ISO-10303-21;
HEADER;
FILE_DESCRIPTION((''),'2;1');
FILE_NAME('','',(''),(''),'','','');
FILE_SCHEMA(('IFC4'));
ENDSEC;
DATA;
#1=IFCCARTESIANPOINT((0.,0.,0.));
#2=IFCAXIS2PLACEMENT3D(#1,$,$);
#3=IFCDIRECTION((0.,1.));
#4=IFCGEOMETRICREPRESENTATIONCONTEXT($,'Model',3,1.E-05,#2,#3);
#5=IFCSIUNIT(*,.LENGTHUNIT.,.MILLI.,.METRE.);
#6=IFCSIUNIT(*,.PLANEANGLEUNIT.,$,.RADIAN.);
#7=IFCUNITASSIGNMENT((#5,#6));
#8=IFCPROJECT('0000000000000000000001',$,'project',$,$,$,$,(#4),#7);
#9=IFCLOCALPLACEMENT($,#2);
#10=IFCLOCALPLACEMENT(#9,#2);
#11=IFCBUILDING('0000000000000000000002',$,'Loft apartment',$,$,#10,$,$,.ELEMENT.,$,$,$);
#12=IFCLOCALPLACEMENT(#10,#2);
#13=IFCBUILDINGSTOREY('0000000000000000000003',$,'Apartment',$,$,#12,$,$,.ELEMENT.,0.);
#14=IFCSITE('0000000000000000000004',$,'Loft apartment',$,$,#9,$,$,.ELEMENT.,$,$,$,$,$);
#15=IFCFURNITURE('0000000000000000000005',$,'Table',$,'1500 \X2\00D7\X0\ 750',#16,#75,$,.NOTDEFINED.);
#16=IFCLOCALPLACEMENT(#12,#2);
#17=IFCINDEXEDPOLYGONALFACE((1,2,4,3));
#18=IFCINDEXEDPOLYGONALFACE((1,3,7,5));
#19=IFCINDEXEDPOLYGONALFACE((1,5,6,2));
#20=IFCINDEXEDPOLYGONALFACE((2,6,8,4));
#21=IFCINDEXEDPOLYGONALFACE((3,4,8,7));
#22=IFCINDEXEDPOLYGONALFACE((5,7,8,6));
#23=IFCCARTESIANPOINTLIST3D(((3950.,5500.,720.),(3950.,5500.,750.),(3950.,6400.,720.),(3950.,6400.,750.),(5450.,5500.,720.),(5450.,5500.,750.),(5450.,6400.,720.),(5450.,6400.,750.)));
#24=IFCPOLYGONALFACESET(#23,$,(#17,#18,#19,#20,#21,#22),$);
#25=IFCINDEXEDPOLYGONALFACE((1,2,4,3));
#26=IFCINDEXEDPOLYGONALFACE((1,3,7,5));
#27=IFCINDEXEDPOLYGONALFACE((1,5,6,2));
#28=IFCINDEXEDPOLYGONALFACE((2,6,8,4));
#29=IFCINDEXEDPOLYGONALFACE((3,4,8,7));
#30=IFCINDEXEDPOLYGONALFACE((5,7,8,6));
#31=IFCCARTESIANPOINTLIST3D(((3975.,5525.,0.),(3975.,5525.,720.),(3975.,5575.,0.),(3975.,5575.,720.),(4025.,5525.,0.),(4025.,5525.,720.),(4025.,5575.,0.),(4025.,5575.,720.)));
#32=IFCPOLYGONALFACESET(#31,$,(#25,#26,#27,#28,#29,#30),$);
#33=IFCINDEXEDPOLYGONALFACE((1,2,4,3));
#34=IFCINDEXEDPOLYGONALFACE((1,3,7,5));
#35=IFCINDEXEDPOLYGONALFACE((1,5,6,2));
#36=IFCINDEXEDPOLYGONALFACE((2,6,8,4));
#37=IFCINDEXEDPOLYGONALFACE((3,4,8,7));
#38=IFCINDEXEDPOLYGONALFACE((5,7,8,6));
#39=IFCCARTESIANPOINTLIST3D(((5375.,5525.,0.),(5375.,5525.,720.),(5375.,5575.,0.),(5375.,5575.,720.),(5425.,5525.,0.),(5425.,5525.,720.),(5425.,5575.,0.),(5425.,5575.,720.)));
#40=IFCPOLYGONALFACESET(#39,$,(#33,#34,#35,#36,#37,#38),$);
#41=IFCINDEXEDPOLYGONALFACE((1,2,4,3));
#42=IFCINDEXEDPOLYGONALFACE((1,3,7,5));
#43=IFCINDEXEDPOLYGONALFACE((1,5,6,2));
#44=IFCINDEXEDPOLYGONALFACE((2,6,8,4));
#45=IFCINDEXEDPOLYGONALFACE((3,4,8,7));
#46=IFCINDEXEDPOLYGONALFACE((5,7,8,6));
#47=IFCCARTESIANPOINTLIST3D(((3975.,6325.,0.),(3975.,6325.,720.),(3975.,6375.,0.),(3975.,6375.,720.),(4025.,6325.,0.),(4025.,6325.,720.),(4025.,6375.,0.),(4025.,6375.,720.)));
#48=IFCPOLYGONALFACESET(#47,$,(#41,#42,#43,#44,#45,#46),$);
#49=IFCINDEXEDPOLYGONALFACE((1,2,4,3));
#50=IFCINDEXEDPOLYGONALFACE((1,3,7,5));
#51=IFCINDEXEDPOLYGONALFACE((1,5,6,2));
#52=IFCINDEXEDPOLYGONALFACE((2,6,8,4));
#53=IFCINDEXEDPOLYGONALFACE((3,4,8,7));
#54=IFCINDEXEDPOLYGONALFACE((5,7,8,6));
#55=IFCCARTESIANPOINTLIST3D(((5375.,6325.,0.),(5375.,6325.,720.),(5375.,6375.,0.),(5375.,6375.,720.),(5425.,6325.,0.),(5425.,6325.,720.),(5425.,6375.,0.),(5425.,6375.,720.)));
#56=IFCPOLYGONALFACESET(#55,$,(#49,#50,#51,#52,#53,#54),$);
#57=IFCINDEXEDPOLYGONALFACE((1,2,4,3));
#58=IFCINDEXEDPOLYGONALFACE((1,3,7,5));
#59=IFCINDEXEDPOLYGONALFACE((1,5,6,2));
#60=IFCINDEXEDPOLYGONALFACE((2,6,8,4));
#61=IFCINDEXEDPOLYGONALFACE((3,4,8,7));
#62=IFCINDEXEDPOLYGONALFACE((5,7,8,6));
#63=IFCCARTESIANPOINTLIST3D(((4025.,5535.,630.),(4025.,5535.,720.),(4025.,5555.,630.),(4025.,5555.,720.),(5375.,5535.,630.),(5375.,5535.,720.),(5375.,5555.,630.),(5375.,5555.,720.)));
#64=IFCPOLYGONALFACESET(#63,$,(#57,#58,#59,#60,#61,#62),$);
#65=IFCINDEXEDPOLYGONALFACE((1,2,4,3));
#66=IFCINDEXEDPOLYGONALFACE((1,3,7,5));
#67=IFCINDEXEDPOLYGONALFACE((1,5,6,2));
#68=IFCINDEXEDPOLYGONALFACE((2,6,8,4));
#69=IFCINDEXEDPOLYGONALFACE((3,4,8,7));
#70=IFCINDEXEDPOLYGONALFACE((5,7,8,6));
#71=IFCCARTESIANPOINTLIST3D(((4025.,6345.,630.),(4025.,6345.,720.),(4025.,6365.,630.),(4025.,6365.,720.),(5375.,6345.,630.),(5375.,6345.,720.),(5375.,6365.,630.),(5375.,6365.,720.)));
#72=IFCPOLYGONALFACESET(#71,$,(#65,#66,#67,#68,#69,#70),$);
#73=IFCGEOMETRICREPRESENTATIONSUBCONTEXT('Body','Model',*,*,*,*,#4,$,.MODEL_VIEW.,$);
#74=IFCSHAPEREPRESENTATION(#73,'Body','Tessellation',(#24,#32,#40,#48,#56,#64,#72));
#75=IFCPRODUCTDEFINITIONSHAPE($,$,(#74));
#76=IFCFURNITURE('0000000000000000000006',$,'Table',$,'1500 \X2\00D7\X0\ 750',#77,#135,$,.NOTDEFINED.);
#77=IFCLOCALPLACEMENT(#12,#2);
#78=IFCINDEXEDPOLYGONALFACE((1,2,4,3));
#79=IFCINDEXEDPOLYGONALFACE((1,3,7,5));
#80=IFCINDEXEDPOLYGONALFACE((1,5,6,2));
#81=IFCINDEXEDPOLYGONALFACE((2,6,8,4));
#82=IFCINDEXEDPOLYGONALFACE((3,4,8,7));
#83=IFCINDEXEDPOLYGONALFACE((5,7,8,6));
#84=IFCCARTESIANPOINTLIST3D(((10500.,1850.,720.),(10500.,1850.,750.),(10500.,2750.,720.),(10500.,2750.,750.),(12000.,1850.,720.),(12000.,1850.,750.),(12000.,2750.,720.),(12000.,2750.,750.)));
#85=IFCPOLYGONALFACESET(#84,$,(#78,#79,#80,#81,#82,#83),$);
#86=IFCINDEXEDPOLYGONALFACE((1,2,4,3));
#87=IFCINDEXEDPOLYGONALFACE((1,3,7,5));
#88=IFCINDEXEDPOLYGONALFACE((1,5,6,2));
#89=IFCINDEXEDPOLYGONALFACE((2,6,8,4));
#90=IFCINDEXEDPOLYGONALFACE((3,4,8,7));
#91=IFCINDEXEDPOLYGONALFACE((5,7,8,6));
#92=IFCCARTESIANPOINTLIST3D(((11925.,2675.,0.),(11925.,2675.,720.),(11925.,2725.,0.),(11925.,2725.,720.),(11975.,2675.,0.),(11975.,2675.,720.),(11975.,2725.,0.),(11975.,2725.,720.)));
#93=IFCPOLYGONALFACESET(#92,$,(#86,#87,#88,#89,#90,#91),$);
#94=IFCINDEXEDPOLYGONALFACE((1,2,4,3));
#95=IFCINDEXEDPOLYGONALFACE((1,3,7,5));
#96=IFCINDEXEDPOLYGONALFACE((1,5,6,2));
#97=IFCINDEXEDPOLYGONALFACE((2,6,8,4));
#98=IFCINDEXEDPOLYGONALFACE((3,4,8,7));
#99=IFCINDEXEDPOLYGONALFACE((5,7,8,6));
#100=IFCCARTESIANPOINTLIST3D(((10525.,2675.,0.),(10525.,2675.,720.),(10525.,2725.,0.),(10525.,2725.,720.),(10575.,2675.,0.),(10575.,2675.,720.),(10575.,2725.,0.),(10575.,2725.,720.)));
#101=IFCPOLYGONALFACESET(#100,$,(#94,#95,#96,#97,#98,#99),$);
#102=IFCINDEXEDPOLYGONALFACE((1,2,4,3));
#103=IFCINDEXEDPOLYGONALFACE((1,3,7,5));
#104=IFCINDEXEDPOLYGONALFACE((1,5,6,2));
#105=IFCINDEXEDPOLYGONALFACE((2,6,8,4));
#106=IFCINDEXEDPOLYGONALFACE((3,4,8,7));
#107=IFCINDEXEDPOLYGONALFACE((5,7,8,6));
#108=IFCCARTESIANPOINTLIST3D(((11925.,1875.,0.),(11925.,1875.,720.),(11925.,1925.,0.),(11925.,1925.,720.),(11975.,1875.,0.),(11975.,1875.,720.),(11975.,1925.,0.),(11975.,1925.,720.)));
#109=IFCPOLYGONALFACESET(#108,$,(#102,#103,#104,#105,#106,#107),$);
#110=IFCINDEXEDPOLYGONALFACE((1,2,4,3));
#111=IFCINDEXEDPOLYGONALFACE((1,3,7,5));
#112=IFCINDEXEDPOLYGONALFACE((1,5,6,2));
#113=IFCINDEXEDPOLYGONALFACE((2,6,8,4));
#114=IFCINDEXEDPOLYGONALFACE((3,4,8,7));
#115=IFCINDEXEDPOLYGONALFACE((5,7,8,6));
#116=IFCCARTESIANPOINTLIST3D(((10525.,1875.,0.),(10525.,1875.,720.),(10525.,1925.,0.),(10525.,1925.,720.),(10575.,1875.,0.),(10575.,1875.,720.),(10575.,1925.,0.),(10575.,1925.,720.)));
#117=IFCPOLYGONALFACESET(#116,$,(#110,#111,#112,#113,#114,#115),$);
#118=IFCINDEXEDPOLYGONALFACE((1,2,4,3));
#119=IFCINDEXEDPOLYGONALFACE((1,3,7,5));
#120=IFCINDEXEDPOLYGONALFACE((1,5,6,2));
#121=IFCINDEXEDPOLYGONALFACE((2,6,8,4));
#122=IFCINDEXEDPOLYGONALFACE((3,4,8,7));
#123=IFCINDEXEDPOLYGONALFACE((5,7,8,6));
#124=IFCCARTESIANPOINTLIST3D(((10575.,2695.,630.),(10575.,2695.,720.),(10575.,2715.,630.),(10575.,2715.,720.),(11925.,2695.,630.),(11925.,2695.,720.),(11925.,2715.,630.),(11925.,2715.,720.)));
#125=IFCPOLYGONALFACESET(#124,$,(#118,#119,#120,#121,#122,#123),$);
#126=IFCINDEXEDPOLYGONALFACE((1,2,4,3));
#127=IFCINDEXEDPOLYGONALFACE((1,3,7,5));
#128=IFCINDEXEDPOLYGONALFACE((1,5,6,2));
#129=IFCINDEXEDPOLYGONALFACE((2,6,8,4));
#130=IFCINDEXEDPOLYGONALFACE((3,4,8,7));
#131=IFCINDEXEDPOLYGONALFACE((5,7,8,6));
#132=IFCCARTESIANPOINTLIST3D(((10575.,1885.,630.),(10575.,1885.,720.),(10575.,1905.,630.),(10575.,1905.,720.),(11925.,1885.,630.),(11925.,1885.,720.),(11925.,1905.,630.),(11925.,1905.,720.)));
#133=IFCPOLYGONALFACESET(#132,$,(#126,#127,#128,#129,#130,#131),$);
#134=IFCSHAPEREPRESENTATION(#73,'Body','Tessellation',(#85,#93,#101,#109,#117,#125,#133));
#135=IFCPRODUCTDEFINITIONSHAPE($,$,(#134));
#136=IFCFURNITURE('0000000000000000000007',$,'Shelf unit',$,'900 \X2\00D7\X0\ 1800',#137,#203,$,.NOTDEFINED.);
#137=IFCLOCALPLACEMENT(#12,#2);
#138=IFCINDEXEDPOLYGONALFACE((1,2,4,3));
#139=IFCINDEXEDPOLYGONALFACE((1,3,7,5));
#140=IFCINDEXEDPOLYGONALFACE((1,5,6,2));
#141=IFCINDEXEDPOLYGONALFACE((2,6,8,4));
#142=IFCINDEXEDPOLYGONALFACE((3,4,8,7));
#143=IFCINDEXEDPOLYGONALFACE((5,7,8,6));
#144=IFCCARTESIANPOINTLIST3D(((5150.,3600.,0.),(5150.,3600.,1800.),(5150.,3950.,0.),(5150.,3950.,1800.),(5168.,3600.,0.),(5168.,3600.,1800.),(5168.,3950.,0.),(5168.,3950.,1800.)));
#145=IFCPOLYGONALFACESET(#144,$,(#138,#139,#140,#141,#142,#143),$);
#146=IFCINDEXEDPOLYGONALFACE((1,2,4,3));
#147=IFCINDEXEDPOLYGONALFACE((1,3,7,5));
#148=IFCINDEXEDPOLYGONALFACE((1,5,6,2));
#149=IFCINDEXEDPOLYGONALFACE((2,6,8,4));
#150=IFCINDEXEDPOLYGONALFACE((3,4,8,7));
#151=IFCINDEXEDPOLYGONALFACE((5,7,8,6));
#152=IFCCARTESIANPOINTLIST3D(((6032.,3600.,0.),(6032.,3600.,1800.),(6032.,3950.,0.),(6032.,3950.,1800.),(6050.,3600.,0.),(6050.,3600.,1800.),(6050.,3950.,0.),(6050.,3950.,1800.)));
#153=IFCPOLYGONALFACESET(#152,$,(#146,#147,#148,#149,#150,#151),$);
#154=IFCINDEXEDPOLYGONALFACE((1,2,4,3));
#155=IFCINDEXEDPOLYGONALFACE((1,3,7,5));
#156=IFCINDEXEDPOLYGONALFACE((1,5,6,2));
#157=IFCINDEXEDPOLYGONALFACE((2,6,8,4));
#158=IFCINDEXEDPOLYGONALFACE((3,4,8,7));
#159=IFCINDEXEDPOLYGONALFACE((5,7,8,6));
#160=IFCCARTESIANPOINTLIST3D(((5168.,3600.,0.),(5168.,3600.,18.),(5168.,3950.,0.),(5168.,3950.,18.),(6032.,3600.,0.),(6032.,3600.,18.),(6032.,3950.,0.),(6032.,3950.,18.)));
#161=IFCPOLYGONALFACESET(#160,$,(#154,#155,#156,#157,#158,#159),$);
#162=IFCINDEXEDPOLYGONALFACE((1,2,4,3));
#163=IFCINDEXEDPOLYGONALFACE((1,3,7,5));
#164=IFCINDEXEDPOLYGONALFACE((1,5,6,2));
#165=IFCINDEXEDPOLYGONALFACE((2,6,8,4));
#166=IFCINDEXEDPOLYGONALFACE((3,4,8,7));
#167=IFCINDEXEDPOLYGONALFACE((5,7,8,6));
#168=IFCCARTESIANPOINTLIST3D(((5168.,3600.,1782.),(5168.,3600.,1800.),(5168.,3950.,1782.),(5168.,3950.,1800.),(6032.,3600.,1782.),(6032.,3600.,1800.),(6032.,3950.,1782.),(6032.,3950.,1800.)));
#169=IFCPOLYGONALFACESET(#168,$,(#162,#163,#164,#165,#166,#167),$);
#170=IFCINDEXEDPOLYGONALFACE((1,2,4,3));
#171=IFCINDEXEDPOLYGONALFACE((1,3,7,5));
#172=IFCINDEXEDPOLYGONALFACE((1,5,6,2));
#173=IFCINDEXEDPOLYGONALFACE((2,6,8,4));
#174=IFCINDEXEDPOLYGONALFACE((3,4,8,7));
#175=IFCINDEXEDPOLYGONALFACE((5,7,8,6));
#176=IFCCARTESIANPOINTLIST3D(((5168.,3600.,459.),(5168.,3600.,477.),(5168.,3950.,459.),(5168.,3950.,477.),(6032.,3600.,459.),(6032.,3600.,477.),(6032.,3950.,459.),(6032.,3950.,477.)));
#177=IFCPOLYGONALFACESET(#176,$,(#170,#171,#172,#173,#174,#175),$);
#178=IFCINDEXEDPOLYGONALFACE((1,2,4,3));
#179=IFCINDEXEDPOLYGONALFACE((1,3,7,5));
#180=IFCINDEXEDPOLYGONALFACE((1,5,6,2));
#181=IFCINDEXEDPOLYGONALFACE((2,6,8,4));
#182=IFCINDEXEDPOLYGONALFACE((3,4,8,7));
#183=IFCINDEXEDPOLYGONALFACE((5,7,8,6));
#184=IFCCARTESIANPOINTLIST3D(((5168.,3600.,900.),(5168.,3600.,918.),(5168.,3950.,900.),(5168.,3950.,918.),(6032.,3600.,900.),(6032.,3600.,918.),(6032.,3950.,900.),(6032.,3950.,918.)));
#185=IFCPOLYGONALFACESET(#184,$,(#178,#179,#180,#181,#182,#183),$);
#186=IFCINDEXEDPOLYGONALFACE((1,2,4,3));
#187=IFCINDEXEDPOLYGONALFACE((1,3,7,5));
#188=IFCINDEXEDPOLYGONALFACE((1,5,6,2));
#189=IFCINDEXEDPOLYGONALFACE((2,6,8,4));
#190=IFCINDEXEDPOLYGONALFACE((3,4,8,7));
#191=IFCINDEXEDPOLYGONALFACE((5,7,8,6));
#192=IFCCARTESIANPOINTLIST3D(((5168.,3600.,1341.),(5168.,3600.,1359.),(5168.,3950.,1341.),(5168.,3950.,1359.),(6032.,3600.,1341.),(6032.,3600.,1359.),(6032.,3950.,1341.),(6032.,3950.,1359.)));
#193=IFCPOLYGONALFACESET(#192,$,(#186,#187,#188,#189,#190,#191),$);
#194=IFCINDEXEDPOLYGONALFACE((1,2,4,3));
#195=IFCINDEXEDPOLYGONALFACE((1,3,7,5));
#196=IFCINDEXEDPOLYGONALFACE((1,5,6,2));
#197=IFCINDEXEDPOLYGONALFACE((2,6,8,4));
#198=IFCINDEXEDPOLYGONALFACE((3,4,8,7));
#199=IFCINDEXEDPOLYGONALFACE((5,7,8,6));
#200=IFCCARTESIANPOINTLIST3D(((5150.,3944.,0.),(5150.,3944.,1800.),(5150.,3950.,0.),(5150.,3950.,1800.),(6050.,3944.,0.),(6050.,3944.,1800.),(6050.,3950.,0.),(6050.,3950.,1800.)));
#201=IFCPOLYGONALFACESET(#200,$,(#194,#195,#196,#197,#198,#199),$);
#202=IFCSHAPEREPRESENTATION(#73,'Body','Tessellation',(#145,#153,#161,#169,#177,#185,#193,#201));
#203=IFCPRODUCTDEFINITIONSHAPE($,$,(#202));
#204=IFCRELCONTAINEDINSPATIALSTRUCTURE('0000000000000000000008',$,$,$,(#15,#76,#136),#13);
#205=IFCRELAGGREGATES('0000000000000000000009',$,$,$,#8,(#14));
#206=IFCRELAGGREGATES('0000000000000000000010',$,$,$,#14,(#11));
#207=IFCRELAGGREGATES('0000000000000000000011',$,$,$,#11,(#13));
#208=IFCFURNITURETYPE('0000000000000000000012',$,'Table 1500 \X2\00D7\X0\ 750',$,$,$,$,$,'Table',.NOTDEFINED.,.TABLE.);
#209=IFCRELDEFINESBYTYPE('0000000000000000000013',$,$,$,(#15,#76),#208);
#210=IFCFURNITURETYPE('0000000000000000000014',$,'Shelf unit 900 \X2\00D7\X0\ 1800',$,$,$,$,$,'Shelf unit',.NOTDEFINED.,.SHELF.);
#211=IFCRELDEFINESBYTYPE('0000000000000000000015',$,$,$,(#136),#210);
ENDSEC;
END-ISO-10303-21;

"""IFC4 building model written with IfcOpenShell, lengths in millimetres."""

from ifc_helpers import new_model, si_unit, direction, frame, origin, place, context, subcontext, project, spatial, polyline, outline, extrude, source, transform, mapped, type_object, type_shapes, element, save


model = new_model("IFC4")

# Units and contexts
model_context = context("Model", 3, precision=1e-05, world=origin(), true_north=direction((0.0, 1.0)))
body_context = subcontext(model_context, "Body", "Model", "MODEL_VIEW")
ifc_project = project(units=[si_unit("LENGTHUNIT", "METRE", prefix="MILLI"), si_unit("PLANEANGLEUNIT", "RADIAN")], contexts=[model_context])

# Site, building, storey
site_placement = place(None, origin())
site = spatial("IfcSite", under=ifc_project, at=site_placement, Name="Loft apartment", CompositionType="ELEMENT")
building_placement = place(site_placement, origin())
building = spatial("IfcBuilding", under=site, at=building_placement, Name="Loft apartment", CompositionType="ELEMENT")
storey_placement = place(building_placement, origin())
storey = spatial("IfcBuildingStorey", under=building, at=storey_placement, Name="Apartment", CompositionType="ELEMENT", Elevation=0.0)

# Furniture
furniture_type_1 = type_object("IfcFurnitureType", Name="Table 1500 × 750", ElementType="Table", AssemblyPlace="NOTDEFINED", PredefinedType="TABLE")
shared_shape_1 = source(origin(), body_context, "Body", "SweptSolid", [
    extrude(outline(polyline([(-750.0, -450.0), (750.0, -450.0), (750.0, 450.0), (-750.0, 450.0), (-750.0, -450.0)])), frame((0.0, 0.0, 720.0)), (0.0, 0.0, 1.0), 30.0),
    extrude(outline(polyline([(-725.0, -425.0), (-675.0, -425.0), (-675.0, -375.0), (-725.0, -375.0), (-725.0, -425.0)])), origin(), (0.0, 0.0, 1.0), 720.0),
    extrude(outline(polyline([(675.0, -425.0), (725.0, -425.0), (725.0, -375.0), (675.0, -375.0), (675.0, -425.0)])), origin(), (0.0, 0.0, 1.0), 720.0),
    extrude(outline(polyline([(-725.0, 375.0), (-675.0, 375.0), (-675.0, 425.0), (-725.0, 425.0), (-725.0, 375.0)])), origin(), (0.0, 0.0, 1.0), 720.0),
    extrude(outline(polyline([(675.0, 375.0), (725.0, 375.0), (725.0, 425.0), (675.0, 425.0), (675.0, 375.0)])), origin(), (0.0, 0.0, 1.0), 720.0),
    extrude(outline(polyline([(-675.0, -415.0), (675.0, -415.0), (675.0, -395.0), (-675.0, -395.0), (-675.0, -415.0)])), frame((0.0, 0.0, 630.0)), (0.0, 0.0, 1.0), 90.0),
    extrude(outline(polyline([(-675.0, 395.0), (675.0, 395.0), (675.0, 415.0), (-675.0, 415.0), (-675.0, 395.0)])), frame((0.0, 0.0, 630.0)), (0.0, 0.0, 1.0), 90.0),
])
type_shapes(furniture_type_1, [shared_shape_1])
for number, where, z_axis, x_axis, name in (
    (1, (4700.0, 5950.0, 0.0), (0.0, 0.0, 1.0), (1.0, 0.0, 0.0), "Table"),
    (2, (11250.0, 2300.0, 0.0), (0.0, 0.0, 1.0), (-1.0, 0.0, 0.0), "Table"),
):
    element("IfcFurniture", number, at=place(storey_placement, frame(where, z_axis=z_axis, x_axis=x_axis)), inside=storey, type_object=furniture_type_1, Name=name, ObjectType="1500 × 750", PredefinedType="NOTDEFINED", context=body_context, shape_type="MappedRepresentation", body=[
        mapped(shared_shape_1, transform((0.0, 0.0, 0.0))),
    ])
furniture_type_2 = type_object("IfcFurnitureType", Name="Shelf unit 900 × 1800", ElementType="Shelf unit", AssemblyPlace="NOTDEFINED", PredefinedType="SHELF")
shared_shape_2 = source(origin(), body_context, "Body", "SweptSolid", [
    extrude(outline(polyline([(-450.0, 0.0), (-432.0, 0.0), (-432.0, 350.0), (-450.0, 350.0), (-450.0, 0.0)])), origin(), (0.0, 0.0, 1.0), 1800.0),
    extrude(outline(polyline([(432.0, 0.0), (450.0, 0.0), (450.0, 350.0), (432.0, 350.0), (432.0, 0.0)])), origin(), (0.0, 0.0, 1.0), 1800.0),
    extrude(outline(polyline([(-432.0, 0.0), (432.0, 0.0), (432.0, 350.0), (-432.0, 350.0), (-432.0, 0.0)])), origin(), (0.0, 0.0, 1.0), 18.0),
    extrude(outline(polyline([(-432.0, 0.0), (432.0, 0.0), (432.0, 350.0), (-432.0, 350.0), (-432.0, 0.0)])), frame((0.0, 0.0, 1782.0)), (0.0, 0.0, 1.0), 18.0),
    extrude(outline(polyline([(-432.0, 0.0), (432.0, 0.0), (432.0, 350.0), (-432.0, 350.0), (-432.0, 0.0)])), frame((0.0, 0.0, 459.0)), (0.0, 0.0, 1.0), 18.0),
    extrude(outline(polyline([(-432.0, 0.0), (432.0, 0.0), (432.0, 350.0), (-432.0, 350.0), (-432.0, 0.0)])), frame((0.0, 0.0, 900.0)), (0.0, 0.0, 1.0), 18.0),
    extrude(outline(polyline([(-432.0, 0.0), (432.0, 0.0), (432.0, 350.0), (-432.0, 350.0), (-432.0, 0.0)])), frame((0.0, 0.0, 1341.0)), (0.0, 0.0, 1.0), 18.0),
    extrude(outline(polyline([(-450.0, 344.0), (450.0, 344.0), (450.0, 350.0), (-450.0, 350.0), (-450.0, 344.0)])), origin(), (0.0, 0.0, 1.0), 1800.0),
])
type_shapes(furniture_type_2, [shared_shape_2])
for number, where, z_axis, x_axis, name in (
    (3, (5600.0, 3600.0, 0.0), (0.0, 0.0, 1.0), (1.0, 0.0, 0.0), "Shelf unit"),
):
    element("IfcFurniture", number, at=place(storey_placement, frame(where, z_axis=z_axis, x_axis=x_axis)), inside=storey, type_object=furniture_type_2, Name=name, ObjectType="900 × 1800", PredefinedType="NOTDEFINED", context=body_context, shape_type="MappedRepresentation", body=[
        mapped(shared_shape_2, transform((0.0, 0.0, 0.0))),
    ])

save(model, "model.ifc")
